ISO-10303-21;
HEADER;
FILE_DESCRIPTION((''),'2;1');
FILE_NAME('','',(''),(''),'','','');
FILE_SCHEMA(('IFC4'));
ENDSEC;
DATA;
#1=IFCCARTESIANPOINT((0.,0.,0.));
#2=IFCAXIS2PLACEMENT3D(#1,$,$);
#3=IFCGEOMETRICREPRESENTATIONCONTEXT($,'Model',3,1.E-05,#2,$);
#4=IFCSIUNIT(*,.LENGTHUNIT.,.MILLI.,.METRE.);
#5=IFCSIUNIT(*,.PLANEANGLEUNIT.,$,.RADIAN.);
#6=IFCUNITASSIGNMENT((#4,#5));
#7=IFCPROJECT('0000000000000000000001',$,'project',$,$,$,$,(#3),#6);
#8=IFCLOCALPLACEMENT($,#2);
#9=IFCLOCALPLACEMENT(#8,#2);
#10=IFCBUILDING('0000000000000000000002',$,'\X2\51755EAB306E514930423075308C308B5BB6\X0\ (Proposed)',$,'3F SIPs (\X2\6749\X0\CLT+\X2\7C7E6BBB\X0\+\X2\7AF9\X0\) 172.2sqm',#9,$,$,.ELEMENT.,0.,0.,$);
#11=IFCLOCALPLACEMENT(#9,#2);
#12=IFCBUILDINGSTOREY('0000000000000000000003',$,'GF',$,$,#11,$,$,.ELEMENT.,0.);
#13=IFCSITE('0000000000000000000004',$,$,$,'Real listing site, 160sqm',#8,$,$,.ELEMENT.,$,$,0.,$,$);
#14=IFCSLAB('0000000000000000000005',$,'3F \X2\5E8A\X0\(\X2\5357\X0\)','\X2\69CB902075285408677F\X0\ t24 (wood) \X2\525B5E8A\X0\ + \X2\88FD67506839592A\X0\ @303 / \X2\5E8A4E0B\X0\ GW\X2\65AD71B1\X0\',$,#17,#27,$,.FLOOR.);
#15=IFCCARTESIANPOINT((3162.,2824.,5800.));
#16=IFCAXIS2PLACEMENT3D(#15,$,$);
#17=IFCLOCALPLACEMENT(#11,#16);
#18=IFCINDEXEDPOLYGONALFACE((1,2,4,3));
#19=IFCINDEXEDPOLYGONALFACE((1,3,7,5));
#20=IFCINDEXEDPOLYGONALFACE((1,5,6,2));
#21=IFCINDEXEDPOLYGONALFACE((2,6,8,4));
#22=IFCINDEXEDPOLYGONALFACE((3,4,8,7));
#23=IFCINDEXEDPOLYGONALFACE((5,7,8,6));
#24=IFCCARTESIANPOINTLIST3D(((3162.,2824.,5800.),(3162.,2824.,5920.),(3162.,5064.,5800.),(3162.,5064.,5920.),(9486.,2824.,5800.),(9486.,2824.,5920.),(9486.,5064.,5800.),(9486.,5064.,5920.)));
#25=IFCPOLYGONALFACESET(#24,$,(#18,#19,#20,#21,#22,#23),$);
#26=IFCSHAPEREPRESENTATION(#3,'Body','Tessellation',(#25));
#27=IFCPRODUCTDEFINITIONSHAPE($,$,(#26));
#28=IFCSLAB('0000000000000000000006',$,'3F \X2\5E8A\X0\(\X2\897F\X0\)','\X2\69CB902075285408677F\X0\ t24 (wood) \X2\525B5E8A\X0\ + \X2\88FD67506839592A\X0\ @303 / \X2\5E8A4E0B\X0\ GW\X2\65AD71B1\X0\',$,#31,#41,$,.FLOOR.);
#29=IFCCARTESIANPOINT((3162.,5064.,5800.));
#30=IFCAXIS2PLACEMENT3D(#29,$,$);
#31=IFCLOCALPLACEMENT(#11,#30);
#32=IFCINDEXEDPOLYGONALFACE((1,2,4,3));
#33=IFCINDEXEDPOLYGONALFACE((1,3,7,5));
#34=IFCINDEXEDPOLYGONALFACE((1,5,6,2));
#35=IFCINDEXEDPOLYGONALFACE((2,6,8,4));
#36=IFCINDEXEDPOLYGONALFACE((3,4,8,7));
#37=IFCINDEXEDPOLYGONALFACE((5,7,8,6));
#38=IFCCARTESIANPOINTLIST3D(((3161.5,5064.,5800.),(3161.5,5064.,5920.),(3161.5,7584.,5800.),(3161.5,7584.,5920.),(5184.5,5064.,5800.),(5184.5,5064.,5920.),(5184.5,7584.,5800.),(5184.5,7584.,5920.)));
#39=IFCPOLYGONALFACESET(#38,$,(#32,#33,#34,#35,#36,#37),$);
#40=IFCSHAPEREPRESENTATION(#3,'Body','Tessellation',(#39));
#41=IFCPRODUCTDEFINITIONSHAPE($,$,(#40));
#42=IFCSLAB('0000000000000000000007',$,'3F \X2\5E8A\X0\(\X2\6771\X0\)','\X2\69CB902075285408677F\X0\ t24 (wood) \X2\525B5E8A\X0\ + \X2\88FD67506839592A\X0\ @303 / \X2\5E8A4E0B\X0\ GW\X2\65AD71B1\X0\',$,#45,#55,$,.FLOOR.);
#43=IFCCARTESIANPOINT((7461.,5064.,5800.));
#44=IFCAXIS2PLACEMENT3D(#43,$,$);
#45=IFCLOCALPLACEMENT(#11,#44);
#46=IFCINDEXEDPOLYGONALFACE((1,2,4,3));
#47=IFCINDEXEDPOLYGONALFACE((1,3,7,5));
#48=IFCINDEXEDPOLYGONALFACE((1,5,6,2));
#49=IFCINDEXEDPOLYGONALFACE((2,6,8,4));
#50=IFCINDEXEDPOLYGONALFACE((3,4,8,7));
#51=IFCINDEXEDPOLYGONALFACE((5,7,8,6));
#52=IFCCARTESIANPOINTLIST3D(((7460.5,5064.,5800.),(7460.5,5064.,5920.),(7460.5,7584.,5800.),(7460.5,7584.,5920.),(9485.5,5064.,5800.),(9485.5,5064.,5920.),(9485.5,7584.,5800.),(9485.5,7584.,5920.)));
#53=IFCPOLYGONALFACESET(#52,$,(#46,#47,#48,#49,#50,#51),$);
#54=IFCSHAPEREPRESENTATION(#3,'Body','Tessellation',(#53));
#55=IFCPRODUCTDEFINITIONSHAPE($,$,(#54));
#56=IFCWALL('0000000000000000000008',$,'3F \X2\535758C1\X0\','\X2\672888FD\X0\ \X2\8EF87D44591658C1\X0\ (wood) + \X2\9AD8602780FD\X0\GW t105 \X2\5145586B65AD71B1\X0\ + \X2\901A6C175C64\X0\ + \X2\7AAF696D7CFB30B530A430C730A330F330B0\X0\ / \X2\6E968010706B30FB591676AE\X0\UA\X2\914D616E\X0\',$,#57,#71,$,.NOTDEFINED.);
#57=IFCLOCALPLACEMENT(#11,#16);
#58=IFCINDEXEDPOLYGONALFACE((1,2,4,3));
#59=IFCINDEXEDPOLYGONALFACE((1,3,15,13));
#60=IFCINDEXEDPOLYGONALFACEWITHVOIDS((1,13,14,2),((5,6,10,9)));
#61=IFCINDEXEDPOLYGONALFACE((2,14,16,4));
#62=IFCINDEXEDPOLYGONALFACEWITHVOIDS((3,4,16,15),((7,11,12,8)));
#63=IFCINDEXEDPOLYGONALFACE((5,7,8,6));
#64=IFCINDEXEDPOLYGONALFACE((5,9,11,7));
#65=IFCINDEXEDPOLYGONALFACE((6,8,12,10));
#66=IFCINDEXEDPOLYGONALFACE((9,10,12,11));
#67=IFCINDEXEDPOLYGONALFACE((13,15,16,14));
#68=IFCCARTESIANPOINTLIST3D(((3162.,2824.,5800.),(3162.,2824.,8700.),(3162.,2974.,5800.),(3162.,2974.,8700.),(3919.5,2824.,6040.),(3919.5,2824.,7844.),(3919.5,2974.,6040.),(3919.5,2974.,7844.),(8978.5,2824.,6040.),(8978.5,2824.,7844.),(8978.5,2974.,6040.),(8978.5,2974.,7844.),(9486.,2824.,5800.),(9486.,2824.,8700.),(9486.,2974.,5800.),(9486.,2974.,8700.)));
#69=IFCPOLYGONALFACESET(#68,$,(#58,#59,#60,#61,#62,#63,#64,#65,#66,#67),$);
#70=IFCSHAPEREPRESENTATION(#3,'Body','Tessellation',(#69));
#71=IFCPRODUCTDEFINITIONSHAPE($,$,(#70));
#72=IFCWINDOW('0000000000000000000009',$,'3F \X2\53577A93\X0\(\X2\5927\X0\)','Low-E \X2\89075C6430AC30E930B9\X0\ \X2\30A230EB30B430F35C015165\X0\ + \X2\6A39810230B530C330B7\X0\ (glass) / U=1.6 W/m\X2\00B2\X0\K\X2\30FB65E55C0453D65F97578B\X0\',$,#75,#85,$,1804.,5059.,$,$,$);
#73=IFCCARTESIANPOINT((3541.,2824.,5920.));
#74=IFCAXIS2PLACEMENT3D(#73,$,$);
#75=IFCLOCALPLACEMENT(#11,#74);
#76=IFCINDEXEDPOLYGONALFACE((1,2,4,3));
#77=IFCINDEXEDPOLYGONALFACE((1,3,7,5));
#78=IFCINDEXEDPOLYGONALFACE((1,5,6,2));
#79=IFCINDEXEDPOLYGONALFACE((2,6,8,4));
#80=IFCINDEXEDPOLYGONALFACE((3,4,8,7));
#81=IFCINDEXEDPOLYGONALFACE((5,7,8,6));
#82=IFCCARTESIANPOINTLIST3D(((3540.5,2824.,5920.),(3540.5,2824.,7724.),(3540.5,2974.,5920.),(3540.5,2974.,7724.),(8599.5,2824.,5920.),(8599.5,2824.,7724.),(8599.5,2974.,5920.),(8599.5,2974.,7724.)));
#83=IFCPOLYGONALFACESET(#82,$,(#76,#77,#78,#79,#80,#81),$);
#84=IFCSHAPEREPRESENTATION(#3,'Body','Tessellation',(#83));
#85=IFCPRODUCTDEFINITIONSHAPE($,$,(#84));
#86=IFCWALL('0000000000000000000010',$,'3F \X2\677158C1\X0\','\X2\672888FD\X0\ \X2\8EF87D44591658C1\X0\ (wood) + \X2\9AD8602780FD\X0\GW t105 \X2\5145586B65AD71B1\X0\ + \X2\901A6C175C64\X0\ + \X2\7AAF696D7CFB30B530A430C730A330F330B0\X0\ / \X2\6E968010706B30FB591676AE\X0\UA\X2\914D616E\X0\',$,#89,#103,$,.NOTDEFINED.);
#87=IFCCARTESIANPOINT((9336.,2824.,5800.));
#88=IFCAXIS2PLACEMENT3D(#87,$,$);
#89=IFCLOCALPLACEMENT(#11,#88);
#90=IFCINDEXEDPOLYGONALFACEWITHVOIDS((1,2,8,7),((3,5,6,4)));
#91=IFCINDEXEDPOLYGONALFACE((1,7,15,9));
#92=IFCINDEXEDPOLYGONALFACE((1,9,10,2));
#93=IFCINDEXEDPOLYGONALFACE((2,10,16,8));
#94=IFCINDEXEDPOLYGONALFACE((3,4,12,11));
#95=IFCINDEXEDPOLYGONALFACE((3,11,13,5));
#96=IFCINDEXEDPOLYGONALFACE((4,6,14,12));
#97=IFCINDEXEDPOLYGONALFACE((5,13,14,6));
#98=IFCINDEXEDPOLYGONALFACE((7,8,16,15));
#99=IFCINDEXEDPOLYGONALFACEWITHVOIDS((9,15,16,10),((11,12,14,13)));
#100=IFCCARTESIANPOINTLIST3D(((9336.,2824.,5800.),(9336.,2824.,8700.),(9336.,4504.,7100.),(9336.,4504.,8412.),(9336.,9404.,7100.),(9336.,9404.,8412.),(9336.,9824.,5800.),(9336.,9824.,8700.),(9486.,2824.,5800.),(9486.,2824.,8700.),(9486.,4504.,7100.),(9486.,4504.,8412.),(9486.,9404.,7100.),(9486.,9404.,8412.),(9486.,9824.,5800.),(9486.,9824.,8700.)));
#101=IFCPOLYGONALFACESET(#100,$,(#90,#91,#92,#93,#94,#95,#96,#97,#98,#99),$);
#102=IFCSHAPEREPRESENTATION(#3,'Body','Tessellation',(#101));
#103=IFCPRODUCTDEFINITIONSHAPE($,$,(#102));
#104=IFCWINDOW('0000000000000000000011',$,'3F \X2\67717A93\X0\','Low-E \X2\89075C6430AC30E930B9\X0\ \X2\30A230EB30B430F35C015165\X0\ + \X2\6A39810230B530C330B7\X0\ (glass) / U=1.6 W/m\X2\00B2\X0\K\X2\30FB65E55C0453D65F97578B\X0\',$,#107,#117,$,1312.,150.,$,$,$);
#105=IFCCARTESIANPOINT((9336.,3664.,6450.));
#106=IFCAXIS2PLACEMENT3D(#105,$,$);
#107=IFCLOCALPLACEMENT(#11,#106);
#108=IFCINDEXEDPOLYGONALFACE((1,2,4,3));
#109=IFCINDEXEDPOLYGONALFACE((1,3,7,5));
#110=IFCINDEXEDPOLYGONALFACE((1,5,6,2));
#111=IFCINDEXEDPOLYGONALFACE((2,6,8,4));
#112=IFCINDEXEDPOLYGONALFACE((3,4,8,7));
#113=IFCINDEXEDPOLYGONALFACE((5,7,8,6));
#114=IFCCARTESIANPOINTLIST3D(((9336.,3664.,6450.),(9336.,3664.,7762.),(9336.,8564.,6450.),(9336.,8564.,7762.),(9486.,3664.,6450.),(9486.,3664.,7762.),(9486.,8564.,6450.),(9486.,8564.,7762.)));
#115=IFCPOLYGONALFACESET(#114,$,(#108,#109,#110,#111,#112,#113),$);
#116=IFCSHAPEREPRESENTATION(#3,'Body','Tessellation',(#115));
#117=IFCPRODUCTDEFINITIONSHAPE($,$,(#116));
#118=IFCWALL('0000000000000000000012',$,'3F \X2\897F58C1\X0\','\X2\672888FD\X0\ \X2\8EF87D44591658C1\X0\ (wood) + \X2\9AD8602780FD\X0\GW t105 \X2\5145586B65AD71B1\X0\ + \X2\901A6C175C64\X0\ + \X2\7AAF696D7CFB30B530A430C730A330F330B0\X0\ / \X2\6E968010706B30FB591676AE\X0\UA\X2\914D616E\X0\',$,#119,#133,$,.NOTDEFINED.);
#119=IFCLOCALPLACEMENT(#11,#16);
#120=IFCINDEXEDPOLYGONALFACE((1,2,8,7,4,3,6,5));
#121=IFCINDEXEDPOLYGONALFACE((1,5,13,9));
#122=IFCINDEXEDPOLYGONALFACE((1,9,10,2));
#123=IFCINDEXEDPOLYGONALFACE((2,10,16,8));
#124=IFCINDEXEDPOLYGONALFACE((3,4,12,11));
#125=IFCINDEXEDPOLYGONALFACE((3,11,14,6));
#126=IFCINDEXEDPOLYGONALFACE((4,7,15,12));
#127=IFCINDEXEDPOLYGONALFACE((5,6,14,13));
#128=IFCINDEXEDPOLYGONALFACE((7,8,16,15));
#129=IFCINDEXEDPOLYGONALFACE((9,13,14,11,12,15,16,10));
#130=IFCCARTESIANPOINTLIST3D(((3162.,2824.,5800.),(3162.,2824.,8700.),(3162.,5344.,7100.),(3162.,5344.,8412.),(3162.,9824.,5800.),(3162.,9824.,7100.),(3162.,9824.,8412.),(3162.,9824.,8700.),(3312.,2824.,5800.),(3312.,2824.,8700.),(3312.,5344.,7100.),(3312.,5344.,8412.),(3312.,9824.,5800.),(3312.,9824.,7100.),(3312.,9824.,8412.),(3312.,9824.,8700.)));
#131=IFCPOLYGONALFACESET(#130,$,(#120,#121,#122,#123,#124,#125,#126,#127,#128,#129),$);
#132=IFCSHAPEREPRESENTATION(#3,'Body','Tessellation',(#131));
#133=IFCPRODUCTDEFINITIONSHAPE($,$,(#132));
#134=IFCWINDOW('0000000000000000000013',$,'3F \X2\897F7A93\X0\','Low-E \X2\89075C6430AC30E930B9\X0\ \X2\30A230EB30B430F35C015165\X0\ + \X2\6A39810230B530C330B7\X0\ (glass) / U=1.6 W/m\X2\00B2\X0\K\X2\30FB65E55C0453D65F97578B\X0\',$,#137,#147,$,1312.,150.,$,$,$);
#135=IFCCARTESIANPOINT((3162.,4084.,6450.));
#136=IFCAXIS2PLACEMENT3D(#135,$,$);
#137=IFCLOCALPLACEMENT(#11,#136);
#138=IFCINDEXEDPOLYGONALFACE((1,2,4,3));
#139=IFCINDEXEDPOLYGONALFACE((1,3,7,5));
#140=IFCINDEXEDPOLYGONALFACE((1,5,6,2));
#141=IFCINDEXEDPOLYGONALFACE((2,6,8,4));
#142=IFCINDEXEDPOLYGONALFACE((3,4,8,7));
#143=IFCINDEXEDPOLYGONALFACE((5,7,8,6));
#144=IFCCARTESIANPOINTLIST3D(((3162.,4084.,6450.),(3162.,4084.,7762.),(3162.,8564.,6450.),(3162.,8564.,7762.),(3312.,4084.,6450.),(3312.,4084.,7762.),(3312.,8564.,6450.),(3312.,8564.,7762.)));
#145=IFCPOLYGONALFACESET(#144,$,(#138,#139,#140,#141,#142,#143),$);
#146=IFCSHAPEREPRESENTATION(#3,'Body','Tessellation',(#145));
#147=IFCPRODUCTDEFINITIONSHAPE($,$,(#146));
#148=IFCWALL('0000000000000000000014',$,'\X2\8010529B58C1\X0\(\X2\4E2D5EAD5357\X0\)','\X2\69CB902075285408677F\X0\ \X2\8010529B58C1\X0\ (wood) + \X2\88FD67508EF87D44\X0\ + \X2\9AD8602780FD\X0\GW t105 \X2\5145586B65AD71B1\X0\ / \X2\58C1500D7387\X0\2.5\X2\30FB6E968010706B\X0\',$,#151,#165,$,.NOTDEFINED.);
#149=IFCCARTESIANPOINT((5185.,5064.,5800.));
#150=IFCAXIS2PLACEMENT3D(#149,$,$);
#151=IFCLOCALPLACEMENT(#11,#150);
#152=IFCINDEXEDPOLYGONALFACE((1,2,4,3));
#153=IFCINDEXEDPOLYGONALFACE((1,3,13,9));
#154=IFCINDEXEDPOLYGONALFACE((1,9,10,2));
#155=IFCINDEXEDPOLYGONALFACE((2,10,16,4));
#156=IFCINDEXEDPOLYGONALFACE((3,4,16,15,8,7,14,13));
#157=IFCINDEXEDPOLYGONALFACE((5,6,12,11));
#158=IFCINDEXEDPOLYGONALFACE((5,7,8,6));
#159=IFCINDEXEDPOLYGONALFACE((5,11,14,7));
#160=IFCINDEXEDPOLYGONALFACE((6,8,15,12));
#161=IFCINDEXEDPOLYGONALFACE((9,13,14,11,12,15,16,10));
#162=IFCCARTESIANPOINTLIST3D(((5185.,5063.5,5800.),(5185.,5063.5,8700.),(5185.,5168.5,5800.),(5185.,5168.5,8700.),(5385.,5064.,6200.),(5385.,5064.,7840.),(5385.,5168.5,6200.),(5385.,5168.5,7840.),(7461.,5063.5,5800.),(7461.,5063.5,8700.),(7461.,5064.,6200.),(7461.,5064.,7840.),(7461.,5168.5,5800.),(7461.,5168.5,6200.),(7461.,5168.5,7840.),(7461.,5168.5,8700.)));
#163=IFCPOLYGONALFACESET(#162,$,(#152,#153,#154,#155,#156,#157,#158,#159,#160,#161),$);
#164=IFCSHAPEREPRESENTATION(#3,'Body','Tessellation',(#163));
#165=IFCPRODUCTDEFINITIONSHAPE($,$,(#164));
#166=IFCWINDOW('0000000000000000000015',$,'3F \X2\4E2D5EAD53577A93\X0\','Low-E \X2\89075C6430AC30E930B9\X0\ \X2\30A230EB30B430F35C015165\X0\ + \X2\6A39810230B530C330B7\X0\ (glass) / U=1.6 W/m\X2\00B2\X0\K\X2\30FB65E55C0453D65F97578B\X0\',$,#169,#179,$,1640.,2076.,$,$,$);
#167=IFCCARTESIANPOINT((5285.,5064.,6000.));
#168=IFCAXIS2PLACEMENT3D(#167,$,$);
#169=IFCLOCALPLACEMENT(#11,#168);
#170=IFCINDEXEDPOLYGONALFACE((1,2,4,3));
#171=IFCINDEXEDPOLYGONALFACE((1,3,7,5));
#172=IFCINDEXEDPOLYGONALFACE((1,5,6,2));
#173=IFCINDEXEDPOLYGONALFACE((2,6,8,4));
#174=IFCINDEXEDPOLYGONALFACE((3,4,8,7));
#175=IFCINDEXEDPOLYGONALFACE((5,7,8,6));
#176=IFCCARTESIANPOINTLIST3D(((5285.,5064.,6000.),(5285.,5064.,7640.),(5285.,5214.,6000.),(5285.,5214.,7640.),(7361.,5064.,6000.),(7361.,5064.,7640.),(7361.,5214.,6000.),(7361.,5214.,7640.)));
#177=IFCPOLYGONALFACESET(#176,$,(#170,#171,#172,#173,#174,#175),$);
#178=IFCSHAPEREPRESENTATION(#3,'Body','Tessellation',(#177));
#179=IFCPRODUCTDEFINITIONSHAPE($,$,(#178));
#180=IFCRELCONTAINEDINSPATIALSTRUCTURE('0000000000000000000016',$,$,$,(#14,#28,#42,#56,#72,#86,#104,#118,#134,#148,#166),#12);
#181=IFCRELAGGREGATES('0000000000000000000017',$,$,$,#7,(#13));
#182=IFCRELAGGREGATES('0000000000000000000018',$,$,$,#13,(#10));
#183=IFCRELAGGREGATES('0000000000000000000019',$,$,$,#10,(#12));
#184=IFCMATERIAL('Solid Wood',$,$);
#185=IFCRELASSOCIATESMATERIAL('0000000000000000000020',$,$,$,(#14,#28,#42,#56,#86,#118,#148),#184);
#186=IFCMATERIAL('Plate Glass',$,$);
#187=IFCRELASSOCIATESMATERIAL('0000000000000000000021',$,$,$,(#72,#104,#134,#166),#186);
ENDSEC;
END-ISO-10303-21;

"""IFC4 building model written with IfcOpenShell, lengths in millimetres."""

from ifc_helpers import new_model, si_unit, frame, frame_2d, origin, place, context, project, spatial, rectangle, extrude, material, element, fill, save


model = new_model("IFC4")

# Units and contexts
model_context = context("Model", 3, precision=1e-05, world=origin())
ifc_project = project(units=[si_unit("LENGTHUNIT", "METRE", prefix="MILLI"), si_unit("PLANEANGLEUNIT", "RADIAN")], contexts=[model_context])

# Site, building, storey
site_placement = place(None, origin())
site = spatial("IfcSite", under=ifc_project, at=site_placement, ObjectType="Real listing site, 160sqm", CompositionType="ELEMENT", RefElevation=0.0)
building_placement = place(site_placement, origin())
building = spatial("IfcBuilding", under=site, at=building_placement, Name="兵庫の光あふれる家 (Proposed)", ObjectType="3F SIPs (杉CLT+籾殻+竹) 172.2sqm", CompositionType="ELEMENT", ElevationOfRefHeight=0.0, ElevationOfTerrain=0.0)
storey_placement = place(building_placement, origin())
storey = spatial("IfcBuildingStorey", under=building, at=storey_placement, Name="GF", CompositionType="ELEMENT", Elevation=0.0)

# Slabs
ifc_material_1 = material(Name="Solid Wood")
slab_1_placement = place(storey_placement, frame((3162.0, 2824.0, 5800.0)))
element("IfcSlab", 1, at=slab_1_placement, inside=storey, material=ifc_material_1, Name="3F 床(南)", Description="構造用合板 t24 (wood) 剛床 + 製材根太 @303 / 床下 GW断熱", PredefinedType="FLOOR", context=model_context, shape_type="SweptSolid", body=[
    extrude(rectangle(XDim=6324.0, YDim=2240.0, at=frame_2d((3162.0, 1120.0))), frame((3162.0, 2824.0, 5800.0)), (0.0, 0.0, 1.0), 120.0),
])
slab_2_placement = place(storey_placement, frame((3162.0, 5064.0, 5800.0)))
element("IfcSlab", 2, at=slab_2_placement, inside=storey, material=ifc_material_1, Name="3F 床(西)", Description="構造用合板 t24 (wood) 剛床 + 製材根太 @303 / 床下 GW断熱", PredefinedType="FLOOR", context=model_context, shape_type="SweptSolid", body=[
    extrude(rectangle(XDim=2023.0, YDim=2520.0, at=frame_2d((1011.0, 1260.0))), frame((3162.0, 5064.0, 5800.0)), (0.0, 0.0, 1.0), 120.0),
])
slab_3_placement = place(storey_placement, frame((7461.0, 5064.0, 5800.0)))
element("IfcSlab", 3, at=slab_3_placement, inside=storey, material=ifc_material_1, Name="3F 床(東)", Description="構造用合板 t24 (wood) 剛床 + 製材根太 @303 / 床下 GW断熱", PredefinedType="FLOOR", context=model_context, shape_type="SweptSolid", body=[
    extrude(rectangle(XDim=2025.0, YDim=2520.0, at=frame_2d((1012.0, 1260.0))), frame((7461.0, 5064.0, 5800.0)), (0.0, 0.0, 1.0), 120.0),
])

# Walls, openings, windows
wall_1_placement = place(storey_placement, frame((3162.0, 2824.0, 5800.0)))
wall_1 = element("IfcWall", 4, at=wall_1_placement, inside=storey, material=ifc_material_1, Name="3F 南壁", Description="木製 軸組外壁 (wood) + 高性能GW t105 充填断熱 + 通気層 + 窯業系サイディング / 準耐火・外皮UA配慮", PredefinedType="NOTDEFINED", context=model_context, shape_type="SweptSolid", body=[
    extrude(rectangle(XDim=6324.0, YDim=150.0, at=frame_2d((3162.0, 75.0))), frame((3162.0, 2824.0, 5800.0)), (0.0, 0.0, 1.0), 2900.0),
])
opening_1_placement = place(storey_placement, frame((3541.0, 2824.0, 5920.0)))
opening_1 = element("IfcOpeningElement", 5, at=opening_1_placement, cuts=wall_1, PredefinedType="NOTDEFINED", context=model_context, shape_type="SweptSolid", body=[
    extrude(rectangle(XDim=5059.0, YDim=150.0, at=frame_2d((2529.0, 75.0))), frame((3541.0, 2824.0, 5920.0)), (0.0, 0.0, 1.0), 1804.0),
])
ifc_material_2 = material(Name="Plate Glass")
window_1_placement = place(storey_placement, frame((3541.0, 2824.0, 5920.0)))
window_1 = element("IfcWindow", 6, at=window_1_placement, inside=storey, material=ifc_material_2, Name="3F 南窓(大)", Description="Low-E 複層ガラス アルゴン封入 + 樹脂サッシ (glass) / U=1.6 W/m²K・日射取得型", OverallHeight=1804.0, OverallWidth=5059.0, context=model_context, shape_type="SweptSolid", body=[
    extrude(rectangle(XDim=5059.0, YDim=150.0, at=frame_2d((2529.0, 75.0))), frame((3541.0, 2824.0, 5920.0)), (0.0, 0.0, 1.0), 1804.0),
])
fill(opening_1, window_1)
wall_2_placement = place(storey_placement, frame((9336.0, 2824.0, 5800.0)))
wall_2 = element("IfcWall", 7, at=wall_2_placement, inside=storey, material=ifc_material_1, Name="3F 東壁", Description="木製 軸組外壁 (wood) + 高性能GW t105 充填断熱 + 通気層 + 窯業系サイディング / 準耐火・外皮UA配慮", PredefinedType="NOTDEFINED", context=model_context, shape_type="SweptSolid", body=[
    extrude(rectangle(XDim=150.0, YDim=7000.0, at=frame_2d((75.0, 3500.0))), frame((9336.0, 2824.0, 5800.0)), (0.0, 0.0, 1.0), 2900.0),
])
opening_2_placement = place(storey_placement, frame((9336.0, 3664.0, 6450.0)))
opening_2 = element("IfcOpeningElement", 8, at=opening_2_placement, cuts=wall_2, PredefinedType="NOTDEFINED", context=model_context, shape_type="SweptSolid", body=[
    extrude(rectangle(XDim=150.0, YDim=4900.0, at=frame_2d((75.0, 2450.0))), frame((9336.0, 3664.0, 6450.0)), (0.0, 0.0, 1.0), 1312.0),
])
window_2_placement = place(storey_placement, frame((9336.0, 3664.0, 6450.0)))
window_2 = element("IfcWindow", 9, at=window_2_placement, inside=storey, material=ifc_material_2, Name="3F 東窓", Description="Low-E 複層ガラス アルゴン封入 + 樹脂サッシ (glass) / U=1.6 W/m²K・日射取得型", OverallHeight=1312.0, OverallWidth=150.0, context=model_context, shape_type="SweptSolid", body=[
    extrude(rectangle(XDim=150.0, YDim=4900.0, at=frame_2d((75.0, 2450.0))), frame((9336.0, 3664.0, 6450.0)), (0.0, 0.0, 1.0), 1312.0),
])
fill(opening_2, window_2)
wall_3_placement = place(storey_placement, frame((3162.0, 2824.0, 5800.0)))
wall_3 = element("IfcWall", 10, at=wall_3_placement, inside=storey, material=ifc_material_1, Name="3F 西壁", Description="木製 軸組外壁 (wood) + 高性能GW t105 充填断熱 + 通気層 + 窯業系サイディング / 準耐火・外皮UA配慮", PredefinedType="NOTDEFINED", context=model_context, shape_type="SweptSolid", body=[
    extrude(rectangle(XDim=150.0, YDim=7000.0, at=frame_2d((75.0, 3500.0))), frame((3162.0, 2824.0, 5800.0)), (0.0, 0.0, 1.0), 2900.0),
])
opening_3_placement = place(storey_placement, frame((3162.0, 4084.0, 6450.0)))
opening_3 = element("IfcOpeningElement", 11, at=opening_3_placement, cuts=wall_3, PredefinedType="NOTDEFINED", context=model_context, shape_type="SweptSolid", body=[
    extrude(rectangle(XDim=150.0, YDim=4480.0, at=frame_2d((75.0, 2240.0))), frame((3162.0, 4084.0, 6450.0)), (0.0, 0.0, 1.0), 1312.0),
])
window_3_placement = place(storey_placement, frame((3162.0, 4084.0, 6450.0)))
window_3 = element("IfcWindow", 12, at=window_3_placement, inside=storey, material=ifc_material_2, Name="3F 西窓", Description="Low-E 複層ガラス アルゴン封入 + 樹脂サッシ (glass) / U=1.6 W/m²K・日射取得型", OverallHeight=1312.0, OverallWidth=150.0, context=model_context, shape_type="SweptSolid", body=[
    extrude(rectangle(XDim=150.0, YDim=4480.0, at=frame_2d((75.0, 2240.0))), frame((3162.0, 4084.0, 6450.0)), (0.0, 0.0, 1.0), 1312.0),
])
fill(opening_3, window_3)
wall_4_placement = place(storey_placement, frame((5185.0, 5064.0, 5800.0)))
wall_4 = element("IfcWall", 13, at=wall_4_placement, inside=storey, material=ifc_material_1, Name="耐力壁(中庭南)", Description="構造用合板 耐力壁 (wood) + 製材軸組 + 高性能GW t105 充填断熱 / 壁倍率2.5・準耐火", PredefinedType="NOTDEFINED", context=model_context, shape_type="SweptSolid", body=[
    extrude(rectangle(XDim=2276.0, YDim=105.0, at=frame_2d((1138.0, 52.0))), frame((5185.0, 5064.0, 5800.0)), (0.0, 0.0, 1.0), 2900.0),
])
opening_4_placement = place(storey_placement, frame((5285.0, 5064.0, 6000.0)))
opening_4 = element("IfcOpeningElement", 14, at=opening_4_placement, cuts=wall_4, PredefinedType="NOTDEFINED", context=model_context, shape_type="SweptSolid", body=[
    extrude(rectangle(XDim=2076.0, YDim=150.0, at=frame_2d((1038.0, 75.0))), frame((5285.0, 5064.0, 6000.0)), (0.0, 0.0, 1.0), 1640.0),
])
window_4_placement = place(storey_placement, frame((5285.0, 5064.0, 6000.0)))
window_4 = element("IfcWindow", 15, at=window_4_placement, inside=storey, material=ifc_material_2, Name="3F 中庭南窓", Description="Low-E 複層ガラス アルゴン封入 + 樹脂サッシ (glass) / U=1.6 W/m²K・日射取得型", OverallHeight=1640.0, OverallWidth=2076.0, context=model_context, shape_type="SweptSolid", body=[
    extrude(rectangle(XDim=2076.0, YDim=150.0, at=frame_2d((1038.0, 75.0))), frame((5285.0, 5064.0, 6000.0)), (0.0, 0.0, 1.0), 1640.0),
])
fill(opening_4, window_4)

save(model, "model.ifc")
